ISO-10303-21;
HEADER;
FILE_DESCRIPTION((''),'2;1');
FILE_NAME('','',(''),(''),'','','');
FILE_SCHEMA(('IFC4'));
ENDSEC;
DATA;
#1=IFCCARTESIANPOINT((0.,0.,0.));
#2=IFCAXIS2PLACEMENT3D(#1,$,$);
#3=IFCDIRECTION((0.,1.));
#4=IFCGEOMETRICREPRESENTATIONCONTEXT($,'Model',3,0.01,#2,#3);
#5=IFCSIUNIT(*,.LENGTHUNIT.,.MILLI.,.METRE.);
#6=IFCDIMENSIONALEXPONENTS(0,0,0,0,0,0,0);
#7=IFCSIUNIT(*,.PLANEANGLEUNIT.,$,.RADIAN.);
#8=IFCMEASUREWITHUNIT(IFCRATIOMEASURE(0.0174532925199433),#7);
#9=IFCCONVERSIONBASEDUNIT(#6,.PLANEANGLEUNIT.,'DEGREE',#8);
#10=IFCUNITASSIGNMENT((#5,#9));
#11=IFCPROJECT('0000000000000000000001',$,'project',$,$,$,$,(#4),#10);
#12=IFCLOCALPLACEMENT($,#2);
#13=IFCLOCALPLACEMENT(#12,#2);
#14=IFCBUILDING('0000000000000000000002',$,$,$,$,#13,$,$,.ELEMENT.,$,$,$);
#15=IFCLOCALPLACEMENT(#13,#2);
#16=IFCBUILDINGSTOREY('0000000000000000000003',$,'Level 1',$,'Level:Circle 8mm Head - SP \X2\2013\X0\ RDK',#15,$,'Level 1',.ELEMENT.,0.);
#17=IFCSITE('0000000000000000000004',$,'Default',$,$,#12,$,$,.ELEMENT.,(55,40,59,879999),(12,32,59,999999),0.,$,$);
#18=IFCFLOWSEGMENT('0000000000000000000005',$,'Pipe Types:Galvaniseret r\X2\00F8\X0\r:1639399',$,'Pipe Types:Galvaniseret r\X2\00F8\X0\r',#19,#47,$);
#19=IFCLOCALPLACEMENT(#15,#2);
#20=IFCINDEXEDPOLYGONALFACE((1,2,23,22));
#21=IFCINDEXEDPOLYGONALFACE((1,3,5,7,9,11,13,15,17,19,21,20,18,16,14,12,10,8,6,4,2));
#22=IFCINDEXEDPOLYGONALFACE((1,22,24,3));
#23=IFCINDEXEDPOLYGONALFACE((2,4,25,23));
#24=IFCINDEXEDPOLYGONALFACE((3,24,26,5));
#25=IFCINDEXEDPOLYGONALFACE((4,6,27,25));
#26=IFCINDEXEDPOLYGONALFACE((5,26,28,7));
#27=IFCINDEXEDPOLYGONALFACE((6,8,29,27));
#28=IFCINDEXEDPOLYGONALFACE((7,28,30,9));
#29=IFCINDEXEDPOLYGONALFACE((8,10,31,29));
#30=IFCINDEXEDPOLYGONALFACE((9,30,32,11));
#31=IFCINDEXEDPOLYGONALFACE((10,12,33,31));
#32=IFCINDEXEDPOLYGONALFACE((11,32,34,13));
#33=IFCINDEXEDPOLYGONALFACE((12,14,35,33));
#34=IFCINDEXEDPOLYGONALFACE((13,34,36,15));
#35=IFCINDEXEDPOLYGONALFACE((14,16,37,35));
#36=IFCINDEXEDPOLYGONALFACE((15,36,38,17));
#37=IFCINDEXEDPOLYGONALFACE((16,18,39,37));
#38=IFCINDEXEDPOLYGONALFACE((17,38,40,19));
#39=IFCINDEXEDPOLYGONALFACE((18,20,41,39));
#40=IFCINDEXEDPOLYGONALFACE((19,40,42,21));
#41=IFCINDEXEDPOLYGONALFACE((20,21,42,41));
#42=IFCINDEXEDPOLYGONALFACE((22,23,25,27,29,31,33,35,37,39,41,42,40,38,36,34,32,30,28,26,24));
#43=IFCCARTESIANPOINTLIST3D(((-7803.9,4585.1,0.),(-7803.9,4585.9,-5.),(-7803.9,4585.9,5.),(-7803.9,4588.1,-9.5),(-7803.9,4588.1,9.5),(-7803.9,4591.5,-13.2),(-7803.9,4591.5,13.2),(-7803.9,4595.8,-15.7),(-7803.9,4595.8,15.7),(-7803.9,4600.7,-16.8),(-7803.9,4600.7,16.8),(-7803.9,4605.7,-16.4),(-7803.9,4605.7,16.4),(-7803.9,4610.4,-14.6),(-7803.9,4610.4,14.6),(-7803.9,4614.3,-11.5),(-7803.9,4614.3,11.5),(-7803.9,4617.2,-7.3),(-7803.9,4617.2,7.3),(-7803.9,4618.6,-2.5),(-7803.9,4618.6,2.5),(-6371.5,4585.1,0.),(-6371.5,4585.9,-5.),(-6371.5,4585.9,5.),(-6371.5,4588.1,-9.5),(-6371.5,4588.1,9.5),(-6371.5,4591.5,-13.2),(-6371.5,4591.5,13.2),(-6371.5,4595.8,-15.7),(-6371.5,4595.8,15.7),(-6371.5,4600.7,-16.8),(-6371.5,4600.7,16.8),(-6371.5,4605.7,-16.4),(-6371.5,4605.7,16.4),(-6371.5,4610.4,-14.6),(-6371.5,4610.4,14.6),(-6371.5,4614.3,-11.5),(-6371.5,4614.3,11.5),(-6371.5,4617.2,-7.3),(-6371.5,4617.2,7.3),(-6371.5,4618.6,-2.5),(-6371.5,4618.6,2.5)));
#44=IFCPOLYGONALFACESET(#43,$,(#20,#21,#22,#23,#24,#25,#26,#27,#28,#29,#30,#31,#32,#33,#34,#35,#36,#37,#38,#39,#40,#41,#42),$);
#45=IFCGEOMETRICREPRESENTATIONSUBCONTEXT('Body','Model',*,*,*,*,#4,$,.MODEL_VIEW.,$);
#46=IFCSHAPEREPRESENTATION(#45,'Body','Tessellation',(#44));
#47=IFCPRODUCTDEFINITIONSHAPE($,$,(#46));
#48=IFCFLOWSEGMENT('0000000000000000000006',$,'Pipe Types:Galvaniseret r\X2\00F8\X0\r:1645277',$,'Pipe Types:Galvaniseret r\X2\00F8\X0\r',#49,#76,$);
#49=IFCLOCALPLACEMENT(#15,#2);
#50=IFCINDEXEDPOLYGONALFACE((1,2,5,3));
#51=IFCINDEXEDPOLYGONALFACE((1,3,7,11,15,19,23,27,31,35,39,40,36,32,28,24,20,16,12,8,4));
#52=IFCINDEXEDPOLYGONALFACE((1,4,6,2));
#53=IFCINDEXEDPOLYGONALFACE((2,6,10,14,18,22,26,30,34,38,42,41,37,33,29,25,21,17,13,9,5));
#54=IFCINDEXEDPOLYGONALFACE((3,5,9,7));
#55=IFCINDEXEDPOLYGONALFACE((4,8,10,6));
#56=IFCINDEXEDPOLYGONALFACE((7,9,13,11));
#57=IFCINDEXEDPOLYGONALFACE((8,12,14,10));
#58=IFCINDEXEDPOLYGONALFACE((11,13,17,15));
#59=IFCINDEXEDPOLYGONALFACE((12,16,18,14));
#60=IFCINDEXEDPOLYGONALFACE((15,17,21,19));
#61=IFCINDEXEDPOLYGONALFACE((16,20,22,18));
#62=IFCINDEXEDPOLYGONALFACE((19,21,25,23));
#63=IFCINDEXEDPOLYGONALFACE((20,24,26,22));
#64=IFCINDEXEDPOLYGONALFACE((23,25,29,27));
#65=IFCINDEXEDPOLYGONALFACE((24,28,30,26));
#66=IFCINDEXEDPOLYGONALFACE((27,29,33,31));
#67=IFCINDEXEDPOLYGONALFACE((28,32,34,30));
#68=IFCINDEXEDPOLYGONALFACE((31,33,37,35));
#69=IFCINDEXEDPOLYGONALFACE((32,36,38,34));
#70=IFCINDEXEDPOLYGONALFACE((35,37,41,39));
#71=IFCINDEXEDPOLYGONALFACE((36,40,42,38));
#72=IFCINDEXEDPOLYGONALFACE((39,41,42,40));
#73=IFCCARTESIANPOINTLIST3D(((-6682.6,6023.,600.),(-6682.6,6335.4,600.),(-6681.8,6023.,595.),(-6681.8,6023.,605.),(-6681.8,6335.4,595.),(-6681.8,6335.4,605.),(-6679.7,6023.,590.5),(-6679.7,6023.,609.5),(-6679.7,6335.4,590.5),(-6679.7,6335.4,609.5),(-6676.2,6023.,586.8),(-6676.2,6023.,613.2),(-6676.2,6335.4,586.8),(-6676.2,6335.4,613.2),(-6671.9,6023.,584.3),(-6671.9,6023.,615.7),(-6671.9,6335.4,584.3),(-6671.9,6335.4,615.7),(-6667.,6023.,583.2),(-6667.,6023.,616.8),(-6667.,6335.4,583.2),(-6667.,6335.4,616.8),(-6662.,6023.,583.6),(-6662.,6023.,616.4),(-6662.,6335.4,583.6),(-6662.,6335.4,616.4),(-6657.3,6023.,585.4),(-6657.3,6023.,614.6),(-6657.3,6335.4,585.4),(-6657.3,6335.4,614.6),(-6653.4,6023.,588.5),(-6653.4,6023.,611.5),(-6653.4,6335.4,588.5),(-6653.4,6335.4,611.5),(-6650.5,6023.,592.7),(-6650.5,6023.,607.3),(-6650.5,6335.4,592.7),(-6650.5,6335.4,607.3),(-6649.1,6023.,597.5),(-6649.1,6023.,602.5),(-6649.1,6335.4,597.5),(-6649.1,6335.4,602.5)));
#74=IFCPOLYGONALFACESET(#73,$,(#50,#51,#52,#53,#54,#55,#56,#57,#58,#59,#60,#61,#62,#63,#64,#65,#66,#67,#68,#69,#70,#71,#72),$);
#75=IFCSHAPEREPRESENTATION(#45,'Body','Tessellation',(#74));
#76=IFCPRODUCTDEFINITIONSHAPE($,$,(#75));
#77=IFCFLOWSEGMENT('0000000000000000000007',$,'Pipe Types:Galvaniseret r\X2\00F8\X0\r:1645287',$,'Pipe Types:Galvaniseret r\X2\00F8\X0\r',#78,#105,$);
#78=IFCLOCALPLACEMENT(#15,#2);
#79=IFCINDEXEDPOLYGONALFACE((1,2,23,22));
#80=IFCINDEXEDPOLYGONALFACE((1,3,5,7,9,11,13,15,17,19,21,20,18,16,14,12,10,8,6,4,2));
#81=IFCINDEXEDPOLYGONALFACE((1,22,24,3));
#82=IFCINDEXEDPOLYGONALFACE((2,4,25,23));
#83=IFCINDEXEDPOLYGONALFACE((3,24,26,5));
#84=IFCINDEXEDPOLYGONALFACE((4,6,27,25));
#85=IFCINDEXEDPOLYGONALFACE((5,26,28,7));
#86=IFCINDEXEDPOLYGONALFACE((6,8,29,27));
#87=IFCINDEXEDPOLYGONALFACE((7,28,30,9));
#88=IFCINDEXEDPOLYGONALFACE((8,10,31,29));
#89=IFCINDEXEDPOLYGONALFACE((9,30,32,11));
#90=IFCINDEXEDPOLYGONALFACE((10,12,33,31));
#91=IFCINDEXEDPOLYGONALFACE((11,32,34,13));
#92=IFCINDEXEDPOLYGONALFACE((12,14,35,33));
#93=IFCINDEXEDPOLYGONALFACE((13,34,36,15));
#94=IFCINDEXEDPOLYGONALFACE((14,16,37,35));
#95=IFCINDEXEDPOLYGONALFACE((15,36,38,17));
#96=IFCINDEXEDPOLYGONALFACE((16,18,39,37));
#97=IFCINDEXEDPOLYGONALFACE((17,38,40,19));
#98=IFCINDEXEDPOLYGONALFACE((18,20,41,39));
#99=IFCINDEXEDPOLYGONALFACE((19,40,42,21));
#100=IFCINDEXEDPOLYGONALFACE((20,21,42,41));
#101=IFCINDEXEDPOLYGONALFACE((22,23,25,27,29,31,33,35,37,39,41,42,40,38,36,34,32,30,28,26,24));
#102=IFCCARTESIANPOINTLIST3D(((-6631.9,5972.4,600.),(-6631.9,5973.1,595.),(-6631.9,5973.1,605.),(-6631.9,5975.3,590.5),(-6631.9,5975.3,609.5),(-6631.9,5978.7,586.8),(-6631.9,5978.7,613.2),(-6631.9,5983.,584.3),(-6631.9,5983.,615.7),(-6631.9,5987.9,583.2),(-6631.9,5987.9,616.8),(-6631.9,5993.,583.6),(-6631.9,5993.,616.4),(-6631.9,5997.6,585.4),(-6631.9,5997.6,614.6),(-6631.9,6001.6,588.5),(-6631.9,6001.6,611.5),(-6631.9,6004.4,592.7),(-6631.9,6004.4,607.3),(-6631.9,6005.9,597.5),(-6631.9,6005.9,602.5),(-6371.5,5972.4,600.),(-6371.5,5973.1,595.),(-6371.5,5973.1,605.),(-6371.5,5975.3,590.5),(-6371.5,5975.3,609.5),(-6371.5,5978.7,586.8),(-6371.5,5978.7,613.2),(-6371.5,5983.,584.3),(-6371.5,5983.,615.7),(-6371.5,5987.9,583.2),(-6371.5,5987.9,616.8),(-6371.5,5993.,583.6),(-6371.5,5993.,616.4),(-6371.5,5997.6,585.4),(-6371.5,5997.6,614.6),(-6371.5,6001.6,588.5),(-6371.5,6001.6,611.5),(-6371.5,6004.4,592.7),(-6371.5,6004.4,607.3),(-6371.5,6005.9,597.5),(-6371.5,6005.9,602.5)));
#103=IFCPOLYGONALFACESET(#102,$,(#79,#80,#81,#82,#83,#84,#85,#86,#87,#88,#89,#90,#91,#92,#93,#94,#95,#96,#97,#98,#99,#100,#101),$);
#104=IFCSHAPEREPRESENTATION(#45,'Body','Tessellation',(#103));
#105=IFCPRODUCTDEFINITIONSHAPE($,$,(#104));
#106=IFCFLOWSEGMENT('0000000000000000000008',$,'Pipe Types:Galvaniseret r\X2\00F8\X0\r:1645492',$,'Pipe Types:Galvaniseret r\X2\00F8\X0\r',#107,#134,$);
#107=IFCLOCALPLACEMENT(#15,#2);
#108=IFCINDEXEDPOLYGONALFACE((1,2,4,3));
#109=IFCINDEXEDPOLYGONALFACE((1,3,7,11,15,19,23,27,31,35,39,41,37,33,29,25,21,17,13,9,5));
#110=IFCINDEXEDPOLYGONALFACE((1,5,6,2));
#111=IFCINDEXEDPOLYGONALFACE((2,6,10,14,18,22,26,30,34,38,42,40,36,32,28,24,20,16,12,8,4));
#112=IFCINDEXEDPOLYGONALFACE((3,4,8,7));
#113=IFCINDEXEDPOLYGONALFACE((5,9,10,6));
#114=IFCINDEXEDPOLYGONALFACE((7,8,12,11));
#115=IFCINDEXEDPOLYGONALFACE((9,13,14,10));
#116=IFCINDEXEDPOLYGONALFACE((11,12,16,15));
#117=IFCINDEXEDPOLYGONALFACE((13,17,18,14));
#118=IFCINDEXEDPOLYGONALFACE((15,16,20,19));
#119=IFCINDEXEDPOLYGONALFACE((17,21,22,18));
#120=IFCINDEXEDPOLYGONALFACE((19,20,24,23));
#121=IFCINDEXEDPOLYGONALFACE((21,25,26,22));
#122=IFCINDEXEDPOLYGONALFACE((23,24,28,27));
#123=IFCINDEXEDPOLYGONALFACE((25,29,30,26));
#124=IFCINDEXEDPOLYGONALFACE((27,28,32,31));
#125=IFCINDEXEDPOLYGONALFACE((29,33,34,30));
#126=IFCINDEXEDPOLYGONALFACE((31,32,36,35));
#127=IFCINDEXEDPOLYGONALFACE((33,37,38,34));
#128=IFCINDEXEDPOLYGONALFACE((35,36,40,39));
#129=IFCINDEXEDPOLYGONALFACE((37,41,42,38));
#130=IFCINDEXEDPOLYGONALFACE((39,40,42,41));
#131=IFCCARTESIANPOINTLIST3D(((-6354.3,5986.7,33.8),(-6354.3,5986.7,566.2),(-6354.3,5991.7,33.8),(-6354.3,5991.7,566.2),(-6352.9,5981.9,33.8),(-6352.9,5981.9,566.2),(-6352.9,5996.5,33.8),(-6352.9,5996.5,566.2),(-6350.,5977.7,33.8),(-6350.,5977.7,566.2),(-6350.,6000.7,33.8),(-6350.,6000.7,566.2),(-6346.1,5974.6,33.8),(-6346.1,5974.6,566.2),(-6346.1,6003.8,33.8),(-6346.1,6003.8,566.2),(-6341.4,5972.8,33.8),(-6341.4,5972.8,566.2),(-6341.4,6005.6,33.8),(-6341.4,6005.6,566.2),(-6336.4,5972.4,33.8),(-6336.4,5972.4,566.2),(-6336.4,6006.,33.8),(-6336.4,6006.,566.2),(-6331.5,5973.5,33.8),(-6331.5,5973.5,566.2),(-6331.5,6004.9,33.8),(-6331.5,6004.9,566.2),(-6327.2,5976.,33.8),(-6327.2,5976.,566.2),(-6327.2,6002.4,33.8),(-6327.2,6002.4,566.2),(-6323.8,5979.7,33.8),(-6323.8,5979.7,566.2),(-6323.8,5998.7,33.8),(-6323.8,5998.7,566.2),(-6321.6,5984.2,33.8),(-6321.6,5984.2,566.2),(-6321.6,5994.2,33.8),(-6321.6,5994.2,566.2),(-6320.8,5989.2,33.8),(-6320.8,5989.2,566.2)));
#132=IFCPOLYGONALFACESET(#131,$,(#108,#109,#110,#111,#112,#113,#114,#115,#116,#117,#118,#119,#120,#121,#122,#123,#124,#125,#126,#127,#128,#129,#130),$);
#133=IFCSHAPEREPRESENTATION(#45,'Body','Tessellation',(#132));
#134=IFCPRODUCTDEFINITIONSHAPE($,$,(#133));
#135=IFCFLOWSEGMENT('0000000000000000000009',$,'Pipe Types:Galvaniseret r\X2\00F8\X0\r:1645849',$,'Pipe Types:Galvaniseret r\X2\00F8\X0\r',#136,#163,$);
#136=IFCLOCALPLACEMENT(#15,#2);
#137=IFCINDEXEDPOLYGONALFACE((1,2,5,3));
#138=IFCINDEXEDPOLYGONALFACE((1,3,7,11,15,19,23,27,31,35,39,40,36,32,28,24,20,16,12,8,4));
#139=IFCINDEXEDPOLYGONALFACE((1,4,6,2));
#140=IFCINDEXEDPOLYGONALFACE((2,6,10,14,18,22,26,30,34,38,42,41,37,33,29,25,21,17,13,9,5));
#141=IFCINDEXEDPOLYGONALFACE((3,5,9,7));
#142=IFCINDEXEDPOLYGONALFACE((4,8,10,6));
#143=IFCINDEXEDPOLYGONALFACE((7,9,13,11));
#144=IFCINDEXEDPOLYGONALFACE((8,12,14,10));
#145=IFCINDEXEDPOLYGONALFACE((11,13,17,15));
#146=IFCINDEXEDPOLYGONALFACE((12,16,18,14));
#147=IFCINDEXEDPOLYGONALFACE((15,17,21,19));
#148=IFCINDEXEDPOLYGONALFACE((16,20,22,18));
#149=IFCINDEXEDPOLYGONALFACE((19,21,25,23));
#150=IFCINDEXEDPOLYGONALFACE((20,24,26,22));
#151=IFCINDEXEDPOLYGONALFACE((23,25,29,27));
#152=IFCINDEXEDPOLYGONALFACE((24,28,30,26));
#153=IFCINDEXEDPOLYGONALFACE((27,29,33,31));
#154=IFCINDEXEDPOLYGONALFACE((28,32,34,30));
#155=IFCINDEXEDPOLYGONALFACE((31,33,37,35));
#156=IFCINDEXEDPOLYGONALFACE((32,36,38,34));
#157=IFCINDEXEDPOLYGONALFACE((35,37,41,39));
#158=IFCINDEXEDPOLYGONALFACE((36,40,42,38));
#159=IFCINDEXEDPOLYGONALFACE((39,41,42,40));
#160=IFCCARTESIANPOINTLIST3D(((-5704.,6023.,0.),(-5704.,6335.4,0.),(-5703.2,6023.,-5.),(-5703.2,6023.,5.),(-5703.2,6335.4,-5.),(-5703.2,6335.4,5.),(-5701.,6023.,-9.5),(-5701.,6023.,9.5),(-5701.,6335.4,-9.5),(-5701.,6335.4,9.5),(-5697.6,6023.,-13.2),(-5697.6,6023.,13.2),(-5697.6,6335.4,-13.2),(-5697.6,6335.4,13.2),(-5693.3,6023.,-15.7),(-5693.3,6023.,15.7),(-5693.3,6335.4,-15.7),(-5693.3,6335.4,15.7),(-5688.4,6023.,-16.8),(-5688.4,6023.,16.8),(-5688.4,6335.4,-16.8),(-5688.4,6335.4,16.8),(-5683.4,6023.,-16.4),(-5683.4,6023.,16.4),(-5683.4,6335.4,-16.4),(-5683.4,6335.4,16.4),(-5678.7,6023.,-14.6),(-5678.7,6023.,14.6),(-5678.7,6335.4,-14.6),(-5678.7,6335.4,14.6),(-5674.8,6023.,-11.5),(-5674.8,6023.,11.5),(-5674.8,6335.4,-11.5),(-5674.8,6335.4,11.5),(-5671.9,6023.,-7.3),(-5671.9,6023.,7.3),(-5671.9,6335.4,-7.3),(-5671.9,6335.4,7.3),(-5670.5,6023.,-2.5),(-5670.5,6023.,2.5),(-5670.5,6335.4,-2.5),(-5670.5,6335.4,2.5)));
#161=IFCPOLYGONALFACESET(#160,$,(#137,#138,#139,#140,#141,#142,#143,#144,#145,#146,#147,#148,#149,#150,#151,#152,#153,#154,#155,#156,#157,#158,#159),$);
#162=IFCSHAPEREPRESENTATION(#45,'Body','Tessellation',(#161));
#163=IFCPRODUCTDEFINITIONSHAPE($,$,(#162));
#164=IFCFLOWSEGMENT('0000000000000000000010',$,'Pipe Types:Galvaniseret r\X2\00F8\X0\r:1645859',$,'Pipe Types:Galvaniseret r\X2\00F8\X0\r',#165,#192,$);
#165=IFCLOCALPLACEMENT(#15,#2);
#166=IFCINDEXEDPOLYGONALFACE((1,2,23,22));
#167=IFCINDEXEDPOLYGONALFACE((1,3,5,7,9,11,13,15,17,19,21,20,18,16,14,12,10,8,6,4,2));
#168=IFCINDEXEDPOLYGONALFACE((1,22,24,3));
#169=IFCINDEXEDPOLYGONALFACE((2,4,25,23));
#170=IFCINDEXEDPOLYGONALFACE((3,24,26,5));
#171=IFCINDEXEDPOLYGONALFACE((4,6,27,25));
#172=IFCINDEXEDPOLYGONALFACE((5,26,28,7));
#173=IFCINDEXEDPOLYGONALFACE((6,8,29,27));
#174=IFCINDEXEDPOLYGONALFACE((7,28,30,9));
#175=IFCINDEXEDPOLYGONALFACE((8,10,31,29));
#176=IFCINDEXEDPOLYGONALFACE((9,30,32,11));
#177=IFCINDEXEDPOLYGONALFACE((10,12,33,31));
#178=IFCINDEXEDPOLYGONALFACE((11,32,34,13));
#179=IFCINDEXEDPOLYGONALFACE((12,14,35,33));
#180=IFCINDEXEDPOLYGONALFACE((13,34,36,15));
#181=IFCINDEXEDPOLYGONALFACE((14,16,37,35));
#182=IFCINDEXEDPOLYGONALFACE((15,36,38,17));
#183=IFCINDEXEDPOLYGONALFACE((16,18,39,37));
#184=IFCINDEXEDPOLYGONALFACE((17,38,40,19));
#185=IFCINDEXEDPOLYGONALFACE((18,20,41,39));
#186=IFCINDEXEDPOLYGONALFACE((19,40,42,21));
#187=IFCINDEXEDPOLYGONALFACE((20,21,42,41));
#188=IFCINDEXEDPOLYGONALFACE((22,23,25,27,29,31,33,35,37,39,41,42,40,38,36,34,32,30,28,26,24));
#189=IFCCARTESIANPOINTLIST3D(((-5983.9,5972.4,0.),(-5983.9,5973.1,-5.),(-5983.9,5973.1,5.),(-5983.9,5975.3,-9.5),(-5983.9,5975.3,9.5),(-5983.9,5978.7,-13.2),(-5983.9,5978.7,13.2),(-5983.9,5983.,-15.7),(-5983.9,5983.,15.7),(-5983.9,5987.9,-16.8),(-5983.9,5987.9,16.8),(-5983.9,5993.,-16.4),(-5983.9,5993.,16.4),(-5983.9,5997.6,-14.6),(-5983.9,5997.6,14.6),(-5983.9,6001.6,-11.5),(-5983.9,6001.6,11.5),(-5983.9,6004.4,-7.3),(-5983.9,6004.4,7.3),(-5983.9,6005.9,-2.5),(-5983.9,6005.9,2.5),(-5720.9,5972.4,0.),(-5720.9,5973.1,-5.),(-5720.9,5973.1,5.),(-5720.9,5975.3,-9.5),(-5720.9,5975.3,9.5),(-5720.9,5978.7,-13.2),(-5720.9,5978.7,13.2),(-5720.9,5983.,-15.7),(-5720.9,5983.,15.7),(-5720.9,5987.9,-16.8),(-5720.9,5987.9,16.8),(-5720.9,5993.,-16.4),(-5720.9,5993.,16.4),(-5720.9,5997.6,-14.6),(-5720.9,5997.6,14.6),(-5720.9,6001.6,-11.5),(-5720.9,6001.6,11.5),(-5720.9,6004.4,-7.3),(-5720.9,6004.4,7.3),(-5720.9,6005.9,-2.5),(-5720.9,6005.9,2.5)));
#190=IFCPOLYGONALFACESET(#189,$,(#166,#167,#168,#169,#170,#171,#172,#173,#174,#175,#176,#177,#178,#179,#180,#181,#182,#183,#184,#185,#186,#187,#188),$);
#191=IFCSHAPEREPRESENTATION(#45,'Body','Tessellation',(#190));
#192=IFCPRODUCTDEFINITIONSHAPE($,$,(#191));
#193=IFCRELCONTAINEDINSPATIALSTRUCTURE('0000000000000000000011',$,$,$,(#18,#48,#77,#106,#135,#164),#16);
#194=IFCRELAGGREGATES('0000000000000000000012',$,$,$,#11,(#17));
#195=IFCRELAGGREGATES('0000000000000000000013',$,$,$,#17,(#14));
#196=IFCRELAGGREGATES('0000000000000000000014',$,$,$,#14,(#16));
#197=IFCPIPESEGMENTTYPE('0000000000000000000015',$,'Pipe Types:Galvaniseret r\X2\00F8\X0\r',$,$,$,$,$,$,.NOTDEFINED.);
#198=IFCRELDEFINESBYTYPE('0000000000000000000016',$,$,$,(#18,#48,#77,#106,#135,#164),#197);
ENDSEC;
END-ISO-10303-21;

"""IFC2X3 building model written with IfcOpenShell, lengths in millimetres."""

from ifc_helpers import new_model, entity, si_unit, converted_unit, direction, frame, frame_2d, origin, origin_2d_with_axis, place, context, subcontext, project, spatial, circle, extrude, type_object, element, save


model = new_model("IFC2X3")

# Units and contexts
model_context = context("Model", 3, precision=0.01, world=origin(), true_north=direction((0.0, 1.0)))
body_context = subcontext(model_context, "Body", "Model", "MODEL_VIEW")
ifc_project = project(units=[si_unit("LENGTHUNIT", "METRE", prefix="MILLI"), converted_unit("PLANEANGLEUNIT", "DEGREE", entity("IfcRatioMeasure", 0.0174532925199433), si_unit("PLANEANGLEUNIT", "RADIAN"), dimensions=[0, 0, 0, 0, 0, 0, 0])], contexts=[model_context])

# Site, building, storey
site_placement = place(None, origin())
site = spatial("IfcSite", under=ifc_project, at=site_placement, Name="Default", CompositionType="ELEMENT", RefLatitude=(55, 40, 59, 879999), RefLongitude=(12, 32, 59, 999999), RefElevation=0.0)
building_placement = place(site_placement, origin())
building = spatial("IfcBuilding", under=site, at=building_placement, CompositionType="ELEMENT")
storey_placement = place(building_placement, origin())
storey = spatial("IfcBuildingStorey", under=building, at=storey_placement, Name="Level 1", ObjectType="Level:Circle 8mm Head - SP – RDK", LongName="Level 1", CompositionType="ELEMENT", Elevation=0.0)

# Flow segments
pipe_segment_type = type_object("IfcPipeSegmentType", Name="Pipe Types:Galvaniseret rør", PredefinedType="NOTDEFINED")
flow_segment_1_placement = place(storey_placement, origin())
element("IfcFlowSegment", 1, at=flow_segment_1_placement, inside=storey, type_object=pipe_segment_type, Name="Pipe Types:Galvaniseret rør:1639399", ObjectType="Pipe Types:Galvaniseret rør", context=body_context, shape_type="SweptSolid", body=[
    extrude(circle(Radius=16.9, at=frame_2d((0.0, 0.0), x_axis=(1.0, 0.0))), frame((-7803.9, 4602.0, 0.0), z_axis=(1.0, 0.0, 0.0), x_axis=(0.0, -1.0, 0.0)), (0.0, 0.0, 1.0), 1432.4),
])
flow_segment_2_placement = place(storey_placement, origin())
element("IfcFlowSegment", 2, at=flow_segment_2_placement, inside=storey, type_object=pipe_segment_type, Name="Pipe Types:Galvaniseret rør:1645277", ObjectType="Pipe Types:Galvaniseret rør", context=body_context, shape_type="SweptSolid", body=[
    extrude(circle(Radius=16.9, at=frame_2d((0.0, 0.0), x_axis=(1.0, 0.0))), frame((-6665.7, 6023.0, 600.0), z_axis=(0.0, 1.0, 0.0), x_axis=(-1.0, 0.0, 0.0)), (0.0, 0.0, 1.0), 312.4),
])
flow_segment_3_placement = place(storey_placement, origin())
element("IfcFlowSegment", 3, at=flow_segment_3_placement, inside=storey, type_object=pipe_segment_type, Name="Pipe Types:Galvaniseret rør:1645287", ObjectType="Pipe Types:Galvaniseret rør", context=body_context, shape_type="SweptSolid", body=[
    extrude(circle(Radius=16.9, at=origin_2d_with_axis()), frame((-6631.9, 5989.2, 600.0), z_axis=(1.0, 0.0, 0.0), x_axis=(0.0, -1.0, 0.0)), (0.0, 0.0, 1.0), 260.4),
])
flow_segment_4_placement = place(storey_placement, origin())
element("IfcFlowSegment", 4, at=flow_segment_4_placement, inside=storey, type_object=pipe_segment_type, Name="Pipe Types:Galvaniseret rør:1645492", ObjectType="Pipe Types:Galvaniseret rør", context=body_context, shape_type="SweptSolid", body=[
    extrude(circle(Radius=16.9, at=origin_2d_with_axis()), frame((-6337.7, 5989.2, 33.8)), (0.0, 0.0, 1.0), 532.4),
])
flow_segment_5_placement = place(storey_placement, origin())
element("IfcFlowSegment", 5, at=flow_segment_5_placement, inside=storey, type_object=pipe_segment_type, Name="Pipe Types:Galvaniseret rør:1645849", ObjectType="Pipe Types:Galvaniseret rør", context=body_context, shape_type="SweptSolid", body=[
    extrude(circle(Radius=16.9, at=frame_2d((0.0, 0.0), x_axis=(1.0, 0.0))), frame((-5687.1, 6023.0, 0.0), z_axis=(0.0, 1.0, 0.0), x_axis=(-1.0, 0.0, 0.0)), (0.0, 0.0, 1.0), 312.4),
])
flow_segment_6_placement = place(storey_placement, origin())
element("IfcFlowSegment", 6, at=flow_segment_6_placement, inside=storey, type_object=pipe_segment_type, Name="Pipe Types:Galvaniseret rør:1645859", ObjectType="Pipe Types:Galvaniseret rør", context=body_context, shape_type="SweptSolid", body=[
    extrude(circle(Radius=16.9, at=frame_2d((0.0, 0.0), x_axis=(1.0, 0.0))), frame((-5983.9, 5989.2, 0.0), z_axis=(1.0, 0.0, 0.0), x_axis=(0.0, -1.0, 0.0)), (0.0, 0.0, 1.0), 263.0),
])

save(model, "model.ifc")
